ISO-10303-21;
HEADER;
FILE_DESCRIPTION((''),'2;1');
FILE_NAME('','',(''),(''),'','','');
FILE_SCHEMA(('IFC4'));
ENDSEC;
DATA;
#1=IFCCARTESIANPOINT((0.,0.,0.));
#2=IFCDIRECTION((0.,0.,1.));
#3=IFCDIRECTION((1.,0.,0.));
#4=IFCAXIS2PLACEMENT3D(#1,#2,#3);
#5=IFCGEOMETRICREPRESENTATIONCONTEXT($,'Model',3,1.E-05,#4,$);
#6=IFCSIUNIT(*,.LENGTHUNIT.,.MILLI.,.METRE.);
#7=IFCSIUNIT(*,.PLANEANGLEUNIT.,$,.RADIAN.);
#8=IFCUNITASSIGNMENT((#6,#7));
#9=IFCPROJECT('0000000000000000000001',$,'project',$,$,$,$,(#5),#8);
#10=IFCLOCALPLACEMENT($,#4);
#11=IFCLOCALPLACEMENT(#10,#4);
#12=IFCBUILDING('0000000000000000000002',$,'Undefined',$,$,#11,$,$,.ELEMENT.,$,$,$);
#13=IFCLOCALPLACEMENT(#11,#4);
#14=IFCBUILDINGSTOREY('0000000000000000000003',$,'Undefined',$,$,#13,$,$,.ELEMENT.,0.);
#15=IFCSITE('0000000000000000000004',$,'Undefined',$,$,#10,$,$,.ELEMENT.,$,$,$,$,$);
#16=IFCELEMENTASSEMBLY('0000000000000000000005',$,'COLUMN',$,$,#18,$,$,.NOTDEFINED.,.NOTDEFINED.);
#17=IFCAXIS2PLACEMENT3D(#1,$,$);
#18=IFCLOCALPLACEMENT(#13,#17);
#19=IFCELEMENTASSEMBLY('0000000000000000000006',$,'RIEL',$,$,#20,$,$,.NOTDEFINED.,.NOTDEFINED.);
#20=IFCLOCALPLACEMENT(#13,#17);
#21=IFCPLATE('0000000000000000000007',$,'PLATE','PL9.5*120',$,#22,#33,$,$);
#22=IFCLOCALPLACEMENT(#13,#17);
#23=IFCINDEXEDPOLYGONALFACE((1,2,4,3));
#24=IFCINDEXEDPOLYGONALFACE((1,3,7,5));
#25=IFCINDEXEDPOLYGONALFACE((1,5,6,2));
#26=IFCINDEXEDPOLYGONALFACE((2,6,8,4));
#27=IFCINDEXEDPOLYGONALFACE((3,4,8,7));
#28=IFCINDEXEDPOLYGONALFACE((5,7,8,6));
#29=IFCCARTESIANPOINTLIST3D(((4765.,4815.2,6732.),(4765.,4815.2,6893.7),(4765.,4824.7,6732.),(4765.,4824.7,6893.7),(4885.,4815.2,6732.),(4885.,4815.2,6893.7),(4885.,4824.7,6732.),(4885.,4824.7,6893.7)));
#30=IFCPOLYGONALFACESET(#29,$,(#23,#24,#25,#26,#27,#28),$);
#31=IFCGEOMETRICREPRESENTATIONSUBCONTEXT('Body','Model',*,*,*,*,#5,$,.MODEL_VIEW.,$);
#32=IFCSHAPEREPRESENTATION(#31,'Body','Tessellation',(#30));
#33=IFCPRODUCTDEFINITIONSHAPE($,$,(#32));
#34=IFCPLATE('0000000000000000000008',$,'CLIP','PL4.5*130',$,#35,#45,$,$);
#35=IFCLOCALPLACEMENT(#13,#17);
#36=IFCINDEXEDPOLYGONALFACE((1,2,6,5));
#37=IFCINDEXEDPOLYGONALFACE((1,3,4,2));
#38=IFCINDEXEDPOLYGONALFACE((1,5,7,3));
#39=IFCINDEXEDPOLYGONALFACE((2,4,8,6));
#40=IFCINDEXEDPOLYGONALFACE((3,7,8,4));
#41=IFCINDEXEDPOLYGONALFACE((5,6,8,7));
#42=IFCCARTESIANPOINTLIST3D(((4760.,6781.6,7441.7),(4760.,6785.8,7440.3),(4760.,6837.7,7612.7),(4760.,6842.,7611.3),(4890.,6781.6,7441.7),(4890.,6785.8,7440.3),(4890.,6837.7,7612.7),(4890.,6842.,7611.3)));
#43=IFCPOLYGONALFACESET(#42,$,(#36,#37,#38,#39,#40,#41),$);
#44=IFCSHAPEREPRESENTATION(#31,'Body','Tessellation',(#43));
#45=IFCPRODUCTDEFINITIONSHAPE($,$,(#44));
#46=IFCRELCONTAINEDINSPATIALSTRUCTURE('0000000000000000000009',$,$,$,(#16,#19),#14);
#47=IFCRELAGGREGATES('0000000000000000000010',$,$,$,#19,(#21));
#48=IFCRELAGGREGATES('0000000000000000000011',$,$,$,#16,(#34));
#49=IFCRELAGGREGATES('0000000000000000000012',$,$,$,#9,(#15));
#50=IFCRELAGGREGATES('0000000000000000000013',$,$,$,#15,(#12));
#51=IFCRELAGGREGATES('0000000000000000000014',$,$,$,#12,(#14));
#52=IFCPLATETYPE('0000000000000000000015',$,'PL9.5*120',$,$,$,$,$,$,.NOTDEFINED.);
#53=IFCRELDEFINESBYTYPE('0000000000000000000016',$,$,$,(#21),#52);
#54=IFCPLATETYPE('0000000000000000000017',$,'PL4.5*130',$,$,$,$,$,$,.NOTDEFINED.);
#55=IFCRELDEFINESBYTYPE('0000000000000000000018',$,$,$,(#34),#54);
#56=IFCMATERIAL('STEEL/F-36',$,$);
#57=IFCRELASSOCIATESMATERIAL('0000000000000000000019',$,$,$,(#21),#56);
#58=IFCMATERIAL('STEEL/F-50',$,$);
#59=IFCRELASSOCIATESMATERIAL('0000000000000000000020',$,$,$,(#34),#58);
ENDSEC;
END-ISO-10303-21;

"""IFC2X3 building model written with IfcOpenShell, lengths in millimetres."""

from ifc_helpers import new_model, si_unit, frame, origin_with_axes, place, context, subcontext, project, spatial, polyline, outline, extrude, material, type_object, element, aggregate, save


model = new_model("IFC2X3")

# Units and contexts
model_context = context("Model", 3, precision=1e-05, world=origin_with_axes())
body_context = subcontext(model_context, "Body", "Model", "MODEL_VIEW")
ifc_project = project(units=[si_unit("LENGTHUNIT", "METRE", prefix="MILLI"), si_unit("PLANEANGLEUNIT", "RADIAN")], contexts=[model_context])

# Site, building, storey
site_placement = place(None, origin_with_axes())
site = spatial("IfcSite", under=ifc_project, at=site_placement, Name="Undefined", CompositionType="ELEMENT")
building_placement = place(site_placement, origin_with_axes())
building = spatial("IfcBuilding", under=site, at=building_placement, Name="Undefined", CompositionType="ELEMENT")
storey_placement = place(building_placement, origin_with_axes())
storey = spatial("IfcBuildingStorey", under=building, at=storey_placement, Name="Undefined", CompositionType="ELEMENT", Elevation=0.0)

# Shared definitions
ifc_material_1 = material(Name="STEEL/F-36")

# Element assembly
assembly_1_placement = place(storey_placement, origin_with_axes())
assembly_1 = element("IfcElementAssembly", 1, at=assembly_1_placement, inside=storey, Name="COLUMN", AssemblyPlace="NOTDEFINED", PredefinedType="NOTDEFINED")

# Shared definitions
ifc_material_2 = material(Name="STEEL/F-50")
plate_type_1 = type_object("IfcPlateType", Name="PL9.5*120", PredefinedType="NOTDEFINED")

# Element assembly, plate
assembly_2_placement = place(storey_placement, origin_with_axes())
assembly_2 = element("IfcElementAssembly", 2, at=assembly_2_placement, inside=storey, Name="RIEL", AssemblyPlace="NOTDEFINED", PredefinedType="NOTDEFINED")
plate_1_placement = place(assembly_2_placement, frame((4885.0, 4820.0, 6732.0), z_axis=(0.0, 1.0, 0.0), x_axis=(-1.0, 0.0, 0.0)))
plate_1 = element("IfcPlate", 3, at=plate_1_placement, type_object=plate_type_1, material=ifc_material_1, Name="PLATE", Description="PL9.5*120", context=body_context, shape_type="SweptSolid", body=[
    extrude(outline(polyline([(0.0, 0.0), (120.0, 0.0), (120.0, 161.7), (0.0, 161.7), (0.0, 0.0)])), frame((0.0, 0.0, -4.8), z_axis=(0.0, 0.0, 1.0), x_axis=(1.0, 0.0, 0.0)), (0.0, 0.0, 1.0), 9.5),
])
aggregate(assembly_2, [plate_1])

# Plate
plate_type_2 = type_object("IfcPlateType", Name="PL4.5*130", PredefinedType="NOTDEFINED")
plate_2_placement = place(assembly_1_placement, frame((4890.0, 6839.8, 7612.0), z_axis=(0.0, 0.950157, -0.311771), x_axis=(0.0, -0.311771, -0.950157)))
plate_2 = element("IfcPlate", 4, at=plate_2_placement, type_object=plate_type_2, material=ifc_material_2, Name="CLIP", Description="PL4.5*130", context=body_context, shape_type="SweptSolid", body=[
    extrude(outline(polyline([(0.0, 0.0), (180.0, 0.0), (180.0, 130.0), (0.0, 130.0), (0.0, 0.0)])), frame((0.0, 0.0, -2.2), z_axis=(0.0, 0.0, 1.0), x_axis=(1.0, 0.0, 0.0)), (0.0, 0.0, 1.0), 4.5),
])

aggregate(assembly_1, [plate_2])

save(model, "model.ifc")
